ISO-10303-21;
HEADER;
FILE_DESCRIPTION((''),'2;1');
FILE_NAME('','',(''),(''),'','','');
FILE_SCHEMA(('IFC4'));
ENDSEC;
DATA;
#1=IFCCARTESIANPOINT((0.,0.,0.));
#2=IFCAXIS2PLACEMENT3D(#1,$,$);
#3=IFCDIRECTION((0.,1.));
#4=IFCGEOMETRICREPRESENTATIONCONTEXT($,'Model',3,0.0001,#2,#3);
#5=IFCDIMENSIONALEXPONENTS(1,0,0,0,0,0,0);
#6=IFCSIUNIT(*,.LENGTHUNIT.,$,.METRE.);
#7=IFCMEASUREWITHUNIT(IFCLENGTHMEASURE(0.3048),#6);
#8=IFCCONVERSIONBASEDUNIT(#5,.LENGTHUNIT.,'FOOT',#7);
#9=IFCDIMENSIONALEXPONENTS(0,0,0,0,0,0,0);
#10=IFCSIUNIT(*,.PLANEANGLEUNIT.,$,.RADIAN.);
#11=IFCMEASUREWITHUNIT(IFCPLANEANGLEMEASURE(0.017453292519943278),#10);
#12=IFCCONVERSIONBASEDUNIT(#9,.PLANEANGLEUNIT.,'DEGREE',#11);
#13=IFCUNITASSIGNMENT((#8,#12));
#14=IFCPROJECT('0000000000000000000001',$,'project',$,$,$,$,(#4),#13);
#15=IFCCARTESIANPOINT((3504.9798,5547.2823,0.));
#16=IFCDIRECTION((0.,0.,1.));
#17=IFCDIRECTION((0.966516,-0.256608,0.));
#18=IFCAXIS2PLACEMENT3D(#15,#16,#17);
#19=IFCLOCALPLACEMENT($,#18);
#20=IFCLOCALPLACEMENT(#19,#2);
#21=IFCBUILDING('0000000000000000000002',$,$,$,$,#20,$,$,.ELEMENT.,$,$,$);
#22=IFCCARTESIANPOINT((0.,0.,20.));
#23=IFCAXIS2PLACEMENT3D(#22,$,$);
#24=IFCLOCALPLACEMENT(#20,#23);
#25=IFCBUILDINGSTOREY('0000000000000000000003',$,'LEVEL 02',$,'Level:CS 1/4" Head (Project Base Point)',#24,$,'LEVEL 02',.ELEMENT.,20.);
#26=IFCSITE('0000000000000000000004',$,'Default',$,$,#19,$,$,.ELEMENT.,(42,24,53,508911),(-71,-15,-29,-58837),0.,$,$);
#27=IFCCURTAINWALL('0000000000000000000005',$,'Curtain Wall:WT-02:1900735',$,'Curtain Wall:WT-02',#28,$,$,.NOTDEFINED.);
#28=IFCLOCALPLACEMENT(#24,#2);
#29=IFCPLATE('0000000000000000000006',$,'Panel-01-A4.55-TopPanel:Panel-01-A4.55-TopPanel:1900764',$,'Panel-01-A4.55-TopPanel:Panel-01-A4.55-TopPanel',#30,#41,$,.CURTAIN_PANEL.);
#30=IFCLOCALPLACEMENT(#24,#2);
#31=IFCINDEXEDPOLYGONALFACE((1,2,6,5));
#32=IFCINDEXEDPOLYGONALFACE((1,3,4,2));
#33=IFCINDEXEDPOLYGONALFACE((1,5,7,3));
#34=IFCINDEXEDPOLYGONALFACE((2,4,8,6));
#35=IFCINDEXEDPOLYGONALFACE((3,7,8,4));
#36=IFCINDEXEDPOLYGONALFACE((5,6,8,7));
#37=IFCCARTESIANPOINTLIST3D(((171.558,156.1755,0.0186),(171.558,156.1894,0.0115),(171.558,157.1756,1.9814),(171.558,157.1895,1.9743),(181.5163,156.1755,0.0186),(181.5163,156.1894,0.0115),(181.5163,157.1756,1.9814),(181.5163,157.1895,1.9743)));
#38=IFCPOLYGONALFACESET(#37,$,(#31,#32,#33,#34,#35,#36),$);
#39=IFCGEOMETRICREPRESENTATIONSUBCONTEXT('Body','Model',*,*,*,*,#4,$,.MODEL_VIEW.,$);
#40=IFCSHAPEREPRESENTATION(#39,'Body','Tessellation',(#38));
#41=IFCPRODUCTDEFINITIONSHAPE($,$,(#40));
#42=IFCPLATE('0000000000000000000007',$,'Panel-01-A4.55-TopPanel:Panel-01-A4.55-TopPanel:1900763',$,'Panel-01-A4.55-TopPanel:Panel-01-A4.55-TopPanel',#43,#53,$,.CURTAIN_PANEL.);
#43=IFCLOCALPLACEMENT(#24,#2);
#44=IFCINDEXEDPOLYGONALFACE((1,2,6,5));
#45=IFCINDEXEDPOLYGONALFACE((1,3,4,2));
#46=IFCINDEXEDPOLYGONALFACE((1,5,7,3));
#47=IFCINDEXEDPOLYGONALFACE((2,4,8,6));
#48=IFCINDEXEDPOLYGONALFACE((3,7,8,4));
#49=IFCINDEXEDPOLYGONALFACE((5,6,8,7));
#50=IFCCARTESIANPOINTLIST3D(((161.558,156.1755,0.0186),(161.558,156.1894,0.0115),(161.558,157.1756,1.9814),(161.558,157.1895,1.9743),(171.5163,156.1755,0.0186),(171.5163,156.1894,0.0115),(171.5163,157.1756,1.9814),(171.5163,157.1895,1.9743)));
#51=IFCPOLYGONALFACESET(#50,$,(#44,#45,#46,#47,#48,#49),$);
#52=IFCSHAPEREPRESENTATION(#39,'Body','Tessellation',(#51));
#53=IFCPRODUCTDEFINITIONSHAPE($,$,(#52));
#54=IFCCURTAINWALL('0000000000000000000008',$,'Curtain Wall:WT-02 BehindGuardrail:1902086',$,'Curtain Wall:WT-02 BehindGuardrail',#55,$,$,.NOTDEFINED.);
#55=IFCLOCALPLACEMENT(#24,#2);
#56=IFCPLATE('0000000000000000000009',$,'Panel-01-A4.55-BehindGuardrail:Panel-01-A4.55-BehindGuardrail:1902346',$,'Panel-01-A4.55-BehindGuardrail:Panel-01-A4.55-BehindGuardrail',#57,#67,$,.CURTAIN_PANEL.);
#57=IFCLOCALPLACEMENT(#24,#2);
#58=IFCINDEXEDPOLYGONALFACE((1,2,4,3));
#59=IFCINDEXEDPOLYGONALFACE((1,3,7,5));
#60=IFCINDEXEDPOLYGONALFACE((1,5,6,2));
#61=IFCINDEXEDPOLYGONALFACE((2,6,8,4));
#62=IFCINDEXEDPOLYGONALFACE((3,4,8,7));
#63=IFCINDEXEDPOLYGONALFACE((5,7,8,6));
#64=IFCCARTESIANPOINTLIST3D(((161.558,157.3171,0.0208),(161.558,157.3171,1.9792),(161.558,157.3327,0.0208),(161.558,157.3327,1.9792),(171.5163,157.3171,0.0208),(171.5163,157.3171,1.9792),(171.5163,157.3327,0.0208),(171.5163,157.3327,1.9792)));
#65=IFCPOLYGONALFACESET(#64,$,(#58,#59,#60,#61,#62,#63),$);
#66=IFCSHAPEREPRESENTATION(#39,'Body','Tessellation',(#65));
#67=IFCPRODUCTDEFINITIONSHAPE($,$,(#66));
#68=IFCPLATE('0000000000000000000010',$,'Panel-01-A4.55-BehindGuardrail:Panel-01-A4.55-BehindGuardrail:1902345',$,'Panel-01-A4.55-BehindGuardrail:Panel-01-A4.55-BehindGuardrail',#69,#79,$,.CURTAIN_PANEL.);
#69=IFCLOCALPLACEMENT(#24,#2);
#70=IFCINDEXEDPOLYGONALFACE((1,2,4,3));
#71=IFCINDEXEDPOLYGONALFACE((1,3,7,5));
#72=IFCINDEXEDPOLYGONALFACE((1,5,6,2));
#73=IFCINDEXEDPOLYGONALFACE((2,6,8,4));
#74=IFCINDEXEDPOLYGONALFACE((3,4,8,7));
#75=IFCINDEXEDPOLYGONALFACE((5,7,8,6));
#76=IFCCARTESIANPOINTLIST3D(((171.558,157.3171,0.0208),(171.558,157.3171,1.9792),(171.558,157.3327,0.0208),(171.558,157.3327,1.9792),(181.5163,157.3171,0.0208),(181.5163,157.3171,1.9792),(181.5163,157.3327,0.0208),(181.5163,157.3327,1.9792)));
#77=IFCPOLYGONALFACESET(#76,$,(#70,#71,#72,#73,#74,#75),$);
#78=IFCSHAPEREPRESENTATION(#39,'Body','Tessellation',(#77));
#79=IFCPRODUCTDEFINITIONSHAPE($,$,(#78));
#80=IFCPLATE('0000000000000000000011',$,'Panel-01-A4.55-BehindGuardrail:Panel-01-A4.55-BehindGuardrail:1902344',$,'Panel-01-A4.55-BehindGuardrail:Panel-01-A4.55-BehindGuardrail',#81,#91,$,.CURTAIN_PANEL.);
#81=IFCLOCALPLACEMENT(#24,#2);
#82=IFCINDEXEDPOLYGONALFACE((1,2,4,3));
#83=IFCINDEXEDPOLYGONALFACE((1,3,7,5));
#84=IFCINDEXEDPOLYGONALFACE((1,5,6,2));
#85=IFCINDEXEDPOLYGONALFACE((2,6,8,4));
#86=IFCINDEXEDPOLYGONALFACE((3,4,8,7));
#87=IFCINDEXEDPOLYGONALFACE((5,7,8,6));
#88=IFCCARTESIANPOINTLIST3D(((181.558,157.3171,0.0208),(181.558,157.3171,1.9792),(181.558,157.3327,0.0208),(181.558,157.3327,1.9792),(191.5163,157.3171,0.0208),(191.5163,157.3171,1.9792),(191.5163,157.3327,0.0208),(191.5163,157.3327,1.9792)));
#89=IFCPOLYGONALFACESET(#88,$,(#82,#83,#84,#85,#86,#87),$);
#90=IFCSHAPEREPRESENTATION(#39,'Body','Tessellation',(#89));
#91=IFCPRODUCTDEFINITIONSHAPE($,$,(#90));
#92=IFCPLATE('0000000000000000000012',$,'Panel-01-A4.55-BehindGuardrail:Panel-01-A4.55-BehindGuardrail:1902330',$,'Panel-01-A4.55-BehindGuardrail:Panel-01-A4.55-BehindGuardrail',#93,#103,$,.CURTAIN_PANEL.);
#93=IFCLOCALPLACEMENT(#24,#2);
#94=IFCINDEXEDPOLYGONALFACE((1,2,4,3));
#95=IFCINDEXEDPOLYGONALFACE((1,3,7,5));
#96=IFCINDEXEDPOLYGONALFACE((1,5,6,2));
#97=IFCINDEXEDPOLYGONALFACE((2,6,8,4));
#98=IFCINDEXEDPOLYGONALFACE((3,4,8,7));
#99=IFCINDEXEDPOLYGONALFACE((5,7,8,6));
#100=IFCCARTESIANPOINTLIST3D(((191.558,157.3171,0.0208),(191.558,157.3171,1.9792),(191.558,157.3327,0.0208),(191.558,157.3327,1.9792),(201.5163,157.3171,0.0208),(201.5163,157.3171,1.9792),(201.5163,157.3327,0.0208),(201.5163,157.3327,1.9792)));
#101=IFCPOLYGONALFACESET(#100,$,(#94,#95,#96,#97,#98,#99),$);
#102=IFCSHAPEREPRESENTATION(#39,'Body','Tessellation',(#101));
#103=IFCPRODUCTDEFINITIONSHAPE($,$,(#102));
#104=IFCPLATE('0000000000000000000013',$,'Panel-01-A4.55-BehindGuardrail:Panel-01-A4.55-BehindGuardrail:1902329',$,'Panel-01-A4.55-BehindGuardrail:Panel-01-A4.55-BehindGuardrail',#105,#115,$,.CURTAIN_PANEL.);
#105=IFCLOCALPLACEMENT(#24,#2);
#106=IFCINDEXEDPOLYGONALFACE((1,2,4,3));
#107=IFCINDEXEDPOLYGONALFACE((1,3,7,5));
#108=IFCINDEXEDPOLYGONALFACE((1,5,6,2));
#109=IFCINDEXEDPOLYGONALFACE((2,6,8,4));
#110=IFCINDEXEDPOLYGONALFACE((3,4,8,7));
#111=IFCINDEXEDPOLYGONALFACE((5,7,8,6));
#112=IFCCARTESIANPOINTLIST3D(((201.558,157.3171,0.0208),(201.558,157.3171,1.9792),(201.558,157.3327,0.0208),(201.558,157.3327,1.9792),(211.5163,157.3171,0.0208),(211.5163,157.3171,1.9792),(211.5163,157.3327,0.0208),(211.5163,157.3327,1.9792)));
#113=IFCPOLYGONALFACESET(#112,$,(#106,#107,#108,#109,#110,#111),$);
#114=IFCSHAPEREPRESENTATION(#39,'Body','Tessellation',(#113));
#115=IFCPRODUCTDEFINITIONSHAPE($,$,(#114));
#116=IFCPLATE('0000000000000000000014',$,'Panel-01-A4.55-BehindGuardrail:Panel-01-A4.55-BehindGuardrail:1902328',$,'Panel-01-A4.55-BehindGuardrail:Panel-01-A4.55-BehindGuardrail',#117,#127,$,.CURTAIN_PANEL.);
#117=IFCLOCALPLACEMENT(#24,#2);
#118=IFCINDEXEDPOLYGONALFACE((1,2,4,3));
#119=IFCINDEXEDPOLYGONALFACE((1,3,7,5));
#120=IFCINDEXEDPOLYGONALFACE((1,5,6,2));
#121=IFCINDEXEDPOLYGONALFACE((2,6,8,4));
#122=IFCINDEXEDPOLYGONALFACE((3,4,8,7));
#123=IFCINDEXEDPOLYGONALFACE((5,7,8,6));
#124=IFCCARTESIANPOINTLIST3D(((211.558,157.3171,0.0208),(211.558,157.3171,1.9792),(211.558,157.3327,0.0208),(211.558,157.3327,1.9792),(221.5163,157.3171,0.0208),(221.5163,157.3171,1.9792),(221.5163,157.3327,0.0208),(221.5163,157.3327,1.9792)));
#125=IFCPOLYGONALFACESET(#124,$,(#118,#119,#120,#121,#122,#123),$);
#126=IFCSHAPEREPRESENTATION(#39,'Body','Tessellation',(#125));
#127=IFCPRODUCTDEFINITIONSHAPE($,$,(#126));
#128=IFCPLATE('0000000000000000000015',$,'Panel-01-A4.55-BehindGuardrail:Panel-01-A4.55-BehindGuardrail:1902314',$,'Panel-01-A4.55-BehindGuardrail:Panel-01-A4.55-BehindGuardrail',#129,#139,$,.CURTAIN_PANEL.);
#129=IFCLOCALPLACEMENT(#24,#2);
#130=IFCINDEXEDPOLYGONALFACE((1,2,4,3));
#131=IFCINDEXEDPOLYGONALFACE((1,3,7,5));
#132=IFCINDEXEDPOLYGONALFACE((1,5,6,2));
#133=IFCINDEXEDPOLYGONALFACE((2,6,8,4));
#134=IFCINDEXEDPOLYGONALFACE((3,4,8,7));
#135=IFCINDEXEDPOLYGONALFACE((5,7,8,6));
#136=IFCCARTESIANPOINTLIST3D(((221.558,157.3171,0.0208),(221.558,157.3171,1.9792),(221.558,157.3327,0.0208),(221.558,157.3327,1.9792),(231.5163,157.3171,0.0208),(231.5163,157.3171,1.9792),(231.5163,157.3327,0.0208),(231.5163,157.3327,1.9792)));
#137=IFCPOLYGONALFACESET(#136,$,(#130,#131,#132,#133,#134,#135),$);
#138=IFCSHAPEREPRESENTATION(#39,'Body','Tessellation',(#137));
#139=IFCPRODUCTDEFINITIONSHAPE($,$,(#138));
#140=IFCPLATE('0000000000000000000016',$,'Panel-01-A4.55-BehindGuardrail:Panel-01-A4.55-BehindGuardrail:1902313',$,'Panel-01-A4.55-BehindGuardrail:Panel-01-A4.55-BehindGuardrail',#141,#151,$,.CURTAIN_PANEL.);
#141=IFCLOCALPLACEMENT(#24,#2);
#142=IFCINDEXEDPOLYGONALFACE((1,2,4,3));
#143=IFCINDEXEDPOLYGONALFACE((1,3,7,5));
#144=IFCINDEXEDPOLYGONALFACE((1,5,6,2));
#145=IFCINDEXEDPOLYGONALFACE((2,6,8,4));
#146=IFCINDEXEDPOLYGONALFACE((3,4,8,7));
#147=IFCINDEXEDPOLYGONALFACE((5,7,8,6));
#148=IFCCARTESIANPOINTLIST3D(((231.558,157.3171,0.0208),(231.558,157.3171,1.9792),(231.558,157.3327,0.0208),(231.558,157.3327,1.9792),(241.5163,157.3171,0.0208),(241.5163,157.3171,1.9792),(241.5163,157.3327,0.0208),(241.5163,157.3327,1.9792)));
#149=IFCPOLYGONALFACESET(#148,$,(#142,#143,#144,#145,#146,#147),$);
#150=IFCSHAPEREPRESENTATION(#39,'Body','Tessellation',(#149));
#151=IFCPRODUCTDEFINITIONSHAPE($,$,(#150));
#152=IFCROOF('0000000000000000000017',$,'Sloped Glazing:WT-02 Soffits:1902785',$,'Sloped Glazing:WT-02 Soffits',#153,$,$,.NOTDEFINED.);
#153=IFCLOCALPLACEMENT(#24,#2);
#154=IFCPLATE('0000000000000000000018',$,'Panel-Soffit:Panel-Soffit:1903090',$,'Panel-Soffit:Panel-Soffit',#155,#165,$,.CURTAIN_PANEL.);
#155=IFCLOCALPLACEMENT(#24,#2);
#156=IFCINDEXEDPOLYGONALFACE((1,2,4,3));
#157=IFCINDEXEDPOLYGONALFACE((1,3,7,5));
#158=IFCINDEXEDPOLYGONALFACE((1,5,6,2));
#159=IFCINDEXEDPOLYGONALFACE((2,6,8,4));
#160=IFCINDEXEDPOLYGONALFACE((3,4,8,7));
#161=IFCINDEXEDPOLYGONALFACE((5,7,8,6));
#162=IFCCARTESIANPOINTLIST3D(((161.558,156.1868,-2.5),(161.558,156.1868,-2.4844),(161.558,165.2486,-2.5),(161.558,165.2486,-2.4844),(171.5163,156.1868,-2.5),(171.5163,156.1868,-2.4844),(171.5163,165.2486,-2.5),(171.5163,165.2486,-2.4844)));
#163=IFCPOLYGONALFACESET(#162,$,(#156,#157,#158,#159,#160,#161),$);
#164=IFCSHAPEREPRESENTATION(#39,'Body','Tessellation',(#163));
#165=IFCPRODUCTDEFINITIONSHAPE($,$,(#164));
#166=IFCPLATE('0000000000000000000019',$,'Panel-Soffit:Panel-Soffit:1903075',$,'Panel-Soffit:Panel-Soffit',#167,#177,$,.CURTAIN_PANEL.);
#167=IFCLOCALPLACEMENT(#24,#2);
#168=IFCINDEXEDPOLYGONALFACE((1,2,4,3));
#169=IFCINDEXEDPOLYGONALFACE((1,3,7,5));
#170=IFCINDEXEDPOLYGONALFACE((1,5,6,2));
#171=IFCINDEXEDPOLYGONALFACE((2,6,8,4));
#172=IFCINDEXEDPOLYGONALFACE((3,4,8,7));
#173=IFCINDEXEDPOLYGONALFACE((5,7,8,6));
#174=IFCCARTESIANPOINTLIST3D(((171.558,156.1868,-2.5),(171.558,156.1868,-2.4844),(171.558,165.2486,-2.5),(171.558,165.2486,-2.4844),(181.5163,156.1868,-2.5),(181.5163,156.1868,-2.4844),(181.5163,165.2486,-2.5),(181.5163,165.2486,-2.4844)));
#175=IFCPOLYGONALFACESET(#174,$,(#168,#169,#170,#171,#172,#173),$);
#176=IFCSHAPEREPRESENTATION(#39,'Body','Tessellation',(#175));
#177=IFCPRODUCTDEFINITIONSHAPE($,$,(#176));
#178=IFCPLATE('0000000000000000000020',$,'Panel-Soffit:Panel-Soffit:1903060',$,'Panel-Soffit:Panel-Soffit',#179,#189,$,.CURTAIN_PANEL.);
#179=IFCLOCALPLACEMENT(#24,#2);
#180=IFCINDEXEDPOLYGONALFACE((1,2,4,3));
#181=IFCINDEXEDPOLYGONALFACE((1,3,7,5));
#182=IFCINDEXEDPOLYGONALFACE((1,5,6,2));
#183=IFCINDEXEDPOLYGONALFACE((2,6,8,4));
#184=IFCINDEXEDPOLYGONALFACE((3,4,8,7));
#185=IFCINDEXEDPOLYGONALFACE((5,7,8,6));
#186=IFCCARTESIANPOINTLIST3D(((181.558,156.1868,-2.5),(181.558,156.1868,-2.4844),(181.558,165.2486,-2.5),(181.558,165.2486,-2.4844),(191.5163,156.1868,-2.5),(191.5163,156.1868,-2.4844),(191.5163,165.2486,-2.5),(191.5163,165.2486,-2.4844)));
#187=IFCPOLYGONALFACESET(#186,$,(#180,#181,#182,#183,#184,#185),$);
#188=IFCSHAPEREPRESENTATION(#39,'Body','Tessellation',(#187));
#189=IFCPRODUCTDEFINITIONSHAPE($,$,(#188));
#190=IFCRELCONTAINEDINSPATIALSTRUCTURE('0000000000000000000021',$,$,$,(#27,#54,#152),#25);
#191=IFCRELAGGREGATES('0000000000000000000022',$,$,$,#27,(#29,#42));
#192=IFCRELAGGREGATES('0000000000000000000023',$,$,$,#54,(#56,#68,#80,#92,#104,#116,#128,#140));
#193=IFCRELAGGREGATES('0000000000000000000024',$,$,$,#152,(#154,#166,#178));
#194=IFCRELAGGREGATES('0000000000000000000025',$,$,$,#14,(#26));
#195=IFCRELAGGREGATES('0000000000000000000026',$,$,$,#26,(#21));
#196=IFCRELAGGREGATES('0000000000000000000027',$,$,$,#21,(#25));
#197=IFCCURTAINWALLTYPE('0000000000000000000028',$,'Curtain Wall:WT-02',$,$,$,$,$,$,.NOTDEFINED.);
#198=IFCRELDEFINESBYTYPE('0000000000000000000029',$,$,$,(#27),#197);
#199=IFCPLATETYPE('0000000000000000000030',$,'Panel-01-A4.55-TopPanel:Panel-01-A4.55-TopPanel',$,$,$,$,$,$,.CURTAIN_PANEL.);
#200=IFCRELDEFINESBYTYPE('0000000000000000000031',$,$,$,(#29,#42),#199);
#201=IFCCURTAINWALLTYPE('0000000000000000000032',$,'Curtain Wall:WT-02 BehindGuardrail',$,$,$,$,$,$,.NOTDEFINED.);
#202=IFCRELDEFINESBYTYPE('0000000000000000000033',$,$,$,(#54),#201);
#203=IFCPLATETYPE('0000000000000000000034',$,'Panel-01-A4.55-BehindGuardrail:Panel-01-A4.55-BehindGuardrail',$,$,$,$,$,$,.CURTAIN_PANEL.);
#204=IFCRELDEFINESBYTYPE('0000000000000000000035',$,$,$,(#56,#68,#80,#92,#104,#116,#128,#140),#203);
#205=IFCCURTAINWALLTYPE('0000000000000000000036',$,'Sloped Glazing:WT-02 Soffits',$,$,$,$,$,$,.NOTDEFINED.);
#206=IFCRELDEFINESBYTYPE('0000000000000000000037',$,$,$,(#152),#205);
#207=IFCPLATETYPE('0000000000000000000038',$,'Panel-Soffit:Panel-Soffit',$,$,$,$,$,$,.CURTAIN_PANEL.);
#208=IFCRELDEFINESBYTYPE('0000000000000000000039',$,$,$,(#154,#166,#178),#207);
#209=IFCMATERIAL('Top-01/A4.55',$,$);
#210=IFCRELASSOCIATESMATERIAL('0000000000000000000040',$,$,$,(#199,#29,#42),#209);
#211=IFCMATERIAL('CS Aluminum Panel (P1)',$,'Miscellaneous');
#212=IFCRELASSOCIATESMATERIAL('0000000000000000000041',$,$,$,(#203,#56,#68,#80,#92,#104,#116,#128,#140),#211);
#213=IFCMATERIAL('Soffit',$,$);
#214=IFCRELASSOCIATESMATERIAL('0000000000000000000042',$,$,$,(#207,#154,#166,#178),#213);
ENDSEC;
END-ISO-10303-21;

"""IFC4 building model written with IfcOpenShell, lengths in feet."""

from ifc_helpers import new_model, entity, si_unit, converted_unit, direction, frame, origin, place, context, subcontext, project, spatial, indexed_curve, outline, extrude, source, transform, mapped, material, type_object, type_shapes, element, aggregate, save


model = new_model("IFC4")

# Units and contexts
model_context = context("Model", 3, precision=0.0001, world=origin(), true_north=direction((0.0, 1.0)))
body_context = subcontext(model_context, "Body", "Model", "MODEL_VIEW")
ifc_project = project(units=[converted_unit("LENGTHUNIT", "FOOT", entity("IfcLengthMeasure", 0.3048), si_unit("LENGTHUNIT", "METRE"), dimensions=[1, 0, 0, 0, 0, 0, 0]), converted_unit("PLANEANGLEUNIT", "DEGREE", entity("IfcPlaneAngleMeasure", 0.017453292519943278), si_unit("PLANEANGLEUNIT", "RADIAN"), dimensions=[0, 0, 0, 0, 0, 0, 0])], contexts=[model_context])

# Site, building, storey
site_placement = place(None, frame((3504.9798, 5547.2823, 0.0), z_axis=(0.0, 0.0, 1.0), x_axis=(0.966516, -0.256608, 0.0)))
site = spatial("IfcSite", under=ifc_project, at=site_placement, Name="Default", CompositionType="ELEMENT", RefLatitude=(42, 24, 53, 508911), RefLongitude=(-71, -15, -29, -58837), RefElevation=0.0)
building_placement = place(site_placement, origin())
building = spatial("IfcBuilding", under=site, at=building_placement, CompositionType="ELEMENT")
storey_placement = place(building_placement, frame((0.0, 0.0, 20.0)))
storey = spatial("IfcBuildingStorey", under=building, at=storey_placement, Name="LEVEL 02", ObjectType="Level:CS 1/4\" Head (Project Base Point)", LongName="LEVEL 02", CompositionType="ELEMENT", Elevation=20.0)

# Curtain walls, plates
curtain_wall_type_1 = type_object("IfcCurtainWallType", Name="Curtain Wall:WT-02", PredefinedType="NOTDEFINED")
ifc_material_1 = material(Name="CS Aluminum Panel (P1)", Category="Miscellaneous")
curtain_wall_1_placement = place(storey_placement, frame((0.0, 0.0, -20.0)))
curtain_wall_1 = element("IfcCurtainWall", 1, at=curtain_wall_1_placement, inside=storey, type_object=curtain_wall_type_1, Name="Curtain Wall:WT-02:1900735", ObjectType="Curtain Wall:WT-02", PredefinedType="NOTDEFINED")
ifc_material_2 = material(Name="Top-01/A4.55")
plate_type_1 = type_object("IfcPlateType", Name="Panel-01-A4.55-TopPanel:Panel-01-A4.55-TopPanel", PredefinedType="CURTAIN_PANEL", material=ifc_material_2)
shared_shape_1 = source(origin(), body_context, "Body", "SweptSolid", [
    extrude(outline(indexed_curve([(-0.0078, -4.9792), (0.0078, -4.9792), (0.0078, 4.9792), (-0.0078, 4.9792), (-0.0078, -4.9792)], self_intersect=False)), frame((0.0, -0.0078, 0.0208), z_axis=(0.0, 0.0, 1.0), x_axis=(0.0, -1.0, 0.0)), (0.0, 0.0, 1.0), 2.203),
])
type_shapes(plate_type_1, [shared_shape_1])
plate_1_placement = place(curtain_wall_1_placement, frame((176.5372, 156.166, 20.0), z_axis=(0.0, 0.45399, 0.891007), x_axis=(-1.0, 0.0, 0.0)))
plate_1 = element("IfcPlate", 2, at=plate_1_placement, type_object=plate_type_1, material=ifc_material_2, Name="Panel-01-A4.55-TopPanel:Panel-01-A4.55-TopPanel:1900764", ObjectType="Panel-01-A4.55-TopPanel:Panel-01-A4.55-TopPanel", PredefinedType="CURTAIN_PANEL", context=body_context, shape_type="MappedRepresentation", body=[
    mapped(shared_shape_1, transform((0.0, 0.0, 0.0), scale=1.0)),
])
plate_2_placement = place(curtain_wall_1_placement, frame((166.5372, 156.166, 20.0), z_axis=(0.0, 0.45399, 0.891007), x_axis=(-1.0, 0.0, 0.0)))
plate_2 = element("IfcPlate", 3, at=plate_2_placement, type_object=plate_type_1, material=ifc_material_2, Name="Panel-01-A4.55-TopPanel:Panel-01-A4.55-TopPanel:1900763", ObjectType="Panel-01-A4.55-TopPanel:Panel-01-A4.55-TopPanel", PredefinedType="CURTAIN_PANEL", context=body_context, shape_type="MappedRepresentation", body=[
    mapped(shared_shape_1, transform((0.0, 0.0, 0.0), scale=1.0)),
])
aggregate(curtain_wall_1, [plate_1, plate_2])
curtain_wall_type_2 = type_object("IfcCurtainWallType", Name="Curtain Wall:WT-02 BehindGuardrail", PredefinedType="NOTDEFINED")
curtain_wall_2_placement = place(storey_placement, frame((0.0, 0.0, -20.0)))
curtain_wall_2 = element("IfcCurtainWall", 4, at=curtain_wall_2_placement, inside=storey, type_object=curtain_wall_type_2, Name="Curtain Wall:WT-02 BehindGuardrail:1902086", ObjectType="Curtain Wall:WT-02 BehindGuardrail", PredefinedType="NOTDEFINED")
plate_type_2 = type_object("IfcPlateType", Name="Panel-01-A4.55-BehindGuardrail:Panel-01-A4.55-BehindGuardrail", PredefinedType="CURTAIN_PANEL", material=ifc_material_1)
shared_shape_2 = source(origin(), body_context, "Body", "SweptSolid", [
    extrude(outline(indexed_curve([(-0.0078, -4.9792), (0.0078, -4.9792), (0.0078, 4.9792), (-0.0078, 4.9792), (-0.0078, -4.9792)], self_intersect=False)), frame((0.0, -0.0078, 0.0208), z_axis=(0.0, 0.0, 1.0), x_axis=(0.0, -1.0, 0.0)), (0.0, 0.0, 1.0), 1.9583),
])
type_shapes(plate_type_2, [shared_shape_2])
plate_3_placement = place(curtain_wall_2_placement, frame((166.5372, 157.3327, 20.0)))
plate_3 = element("IfcPlate", 5, at=plate_3_placement, type_object=plate_type_2, material=ifc_material_1, Name="Panel-01-A4.55-BehindGuardrail:Panel-01-A4.55-BehindGuardrail:1902346", ObjectType="Panel-01-A4.55-BehindGuardrail:Panel-01-A4.55-BehindGuardrail", PredefinedType="CURTAIN_PANEL", context=body_context, shape_type="MappedRepresentation", body=[
    mapped(shared_shape_2, transform((0.0, 0.0, 0.0), scale=1.0)),
])
plate_4_placement = place(curtain_wall_2_placement, frame((176.5372, 157.3327, 20.0)))
plate_4 = element("IfcPlate", 6, at=plate_4_placement, type_object=plate_type_2, material=ifc_material_1, Name="Panel-01-A4.55-BehindGuardrail:Panel-01-A4.55-BehindGuardrail:1902345", ObjectType="Panel-01-A4.55-BehindGuardrail:Panel-01-A4.55-BehindGuardrail", PredefinedType="CURTAIN_PANEL", context=body_context, shape_type="MappedRepresentation", body=[
    mapped(shared_shape_2, transform((0.0, 0.0, 0.0), scale=1.0)),
])
plate_5_placement = place(curtain_wall_2_placement, frame((186.5372, 157.3327, 20.0)))
plate_5 = element("IfcPlate", 7, at=plate_5_placement, type_object=plate_type_2, material=ifc_material_1, Name="Panel-01-A4.55-BehindGuardrail:Panel-01-A4.55-BehindGuardrail:1902344", ObjectType="Panel-01-A4.55-BehindGuardrail:Panel-01-A4.55-BehindGuardrail", PredefinedType="CURTAIN_PANEL", context=body_context, shape_type="MappedRepresentation", body=[
    mapped(shared_shape_2, transform((0.0, 0.0, 0.0), scale=1.0)),
])
plate_6_placement = place(curtain_wall_2_placement, frame((196.5372, 157.3327, 20.0)))
plate_6 = element("IfcPlate", 8, at=plate_6_placement, type_object=plate_type_2, material=ifc_material_1, Name="Panel-01-A4.55-BehindGuardrail:Panel-01-A4.55-BehindGuardrail:1902330", ObjectType="Panel-01-A4.55-BehindGuardrail:Panel-01-A4.55-BehindGuardrail", PredefinedType="CURTAIN_PANEL", context=body_context, shape_type="MappedRepresentation", body=[
    mapped(shared_shape_2, transform((0.0, 0.0, 0.0), scale=1.0)),
])
plate_7_placement = place(curtain_wall_2_placement, frame((206.5372, 157.3327, 20.0)))
plate_7 = element("IfcPlate", 9, at=plate_7_placement, type_object=plate_type_2, material=ifc_material_1, Name="Panel-01-A4.55-BehindGuardrail:Panel-01-A4.55-BehindGuardrail:1902329", ObjectType="Panel-01-A4.55-BehindGuardrail:Panel-01-A4.55-BehindGuardrail", PredefinedType="CURTAIN_PANEL", context=body_context, shape_type="MappedRepresentation", body=[
    mapped(shared_shape_2, transform((0.0, 0.0, 0.0), scale=1.0)),
])
plate_8_placement = place(curtain_wall_2_placement, frame((216.5372, 157.3327, 20.0)))
plate_8 = element("IfcPlate", 10, at=plate_8_placement, type_object=plate_type_2, material=ifc_material_1, Name="Panel-01-A4.55-BehindGuardrail:Panel-01-A4.55-BehindGuardrail:1902328", ObjectType="Panel-01-A4.55-BehindGuardrail:Panel-01-A4.55-BehindGuardrail", PredefinedType="CURTAIN_PANEL", context=body_context, shape_type="MappedRepresentation", body=[
    mapped(shared_shape_2, transform((0.0, 0.0, 0.0), scale=1.0)),
])
plate_9_placement = place(curtain_wall_2_placement, frame((226.5372, 157.3327, 20.0)))
plate_9 = element("IfcPlate", 11, at=plate_9_placement, type_object=plate_type_2, material=ifc_material_1, Name="Panel-01-A4.55-BehindGuardrail:Panel-01-A4.55-BehindGuardrail:1902314", ObjectType="Panel-01-A4.55-BehindGuardrail:Panel-01-A4.55-BehindGuardrail", PredefinedType="CURTAIN_PANEL", context=body_context, shape_type="MappedRepresentation", body=[
    mapped(shared_shape_2, transform((0.0, 0.0, 0.0), scale=1.0)),
])
plate_10_placement = place(curtain_wall_2_placement, frame((236.5372, 157.3327, 20.0)))
plate_10 = element("IfcPlate", 12, at=plate_10_placement, type_object=plate_type_2, material=ifc_material_1, Name="Panel-01-A4.55-BehindGuardrail:Panel-01-A4.55-BehindGuardrail:1902313", ObjectType="Panel-01-A4.55-BehindGuardrail:Panel-01-A4.55-BehindGuardrail", PredefinedType="CURTAIN_PANEL", context=body_context, shape_type="MappedRepresentation", body=[
    mapped(shared_shape_2, transform((0.0, 0.0, 0.0), scale=1.0)),
])
aggregate(curtain_wall_2, [plate_3, plate_4, plate_5, plate_6, plate_7, plate_8, plate_9, plate_10])

# Roof, plates
curtain_wall_type_3 = type_object("IfcCurtainWallType", Name="Sloped Glazing:WT-02 Soffits", PredefinedType="NOTDEFINED")
roof_placement = place(storey_placement, frame((0.0, 0.0, -20.0)))
roof = element("IfcRoof", 13, at=roof_placement, inside=storey, type_object=curtain_wall_type_3, Name="Sloped Glazing:WT-02 Soffits:1902785", ObjectType="Sloped Glazing:WT-02 Soffits", PredefinedType="NOTDEFINED")
ifc_material_3 = material(Name="Soffit")
plate_type_3 = type_object("IfcPlateType", Name="Panel-Soffit:Panel-Soffit", PredefinedType="CURTAIN_PANEL", material=ifc_material_3)
shared_shape_3 = source(origin(), body_context, "Body", "SweptSolid", [
    extrude(outline(indexed_curve([(-0.0078, -4.9792), (0.0078, -4.9792), (0.0078, 4.9792), (-0.0078, 4.9792), (-0.0078, -4.9792)], self_intersect=False)), frame((0.0, -0.0078, 0.0208), z_axis=(0.0, 0.0, 1.0), x_axis=(0.0, -1.0, 0.0)), (0.0, 0.0, 1.0), 9.0617),
])
type_shapes(plate_type_3, [shared_shape_3])
plate_11_placement = place(roof_placement, frame((166.5372, 156.166, 17.5), z_axis=(0.0, 1.0, 0.0), x_axis=(1.0, 0.0, 0.0)))
plate_11 = element("IfcPlate", 14, at=plate_11_placement, type_object=plate_type_3, material=ifc_material_3, Name="Panel-Soffit:Panel-Soffit:1903090", ObjectType="Panel-Soffit:Panel-Soffit", PredefinedType="CURTAIN_PANEL", context=body_context, shape_type="MappedRepresentation", body=[
    mapped(shared_shape_3, transform((0.0, 0.0, 0.0), scale=1.0)),
])
plate_12_placement = place(roof_placement, frame((176.5372, 156.166, 17.5), z_axis=(0.0, 1.0, 0.0), x_axis=(1.0, 0.0, 0.0)))
plate_12 = element("IfcPlate", 15, at=plate_12_placement, type_object=plate_type_3, material=ifc_material_3, Name="Panel-Soffit:Panel-Soffit:1903075", ObjectType="Panel-Soffit:Panel-Soffit", PredefinedType="CURTAIN_PANEL", context=body_context, shape_type="MappedRepresentation", body=[
    mapped(shared_shape_3, transform((0.0, 0.0, 0.0), scale=1.0)),
])
plate_13_placement = place(roof_placement, frame((186.5372, 156.166, 17.5), z_axis=(0.0, 1.0, 0.0), x_axis=(1.0, 0.0, 0.0)))
plate_13 = element("IfcPlate", 16, at=plate_13_placement, type_object=plate_type_3, material=ifc_material_3, Name="Panel-Soffit:Panel-Soffit:1903060", ObjectType="Panel-Soffit:Panel-Soffit", PredefinedType="CURTAIN_PANEL", context=body_context, shape_type="MappedRepresentation", body=[
    mapped(shared_shape_3, transform((0.0, 0.0, 0.0), scale=1.0)),
])
aggregate(roof, [plate_11, plate_12, plate_13])

save(model, "model.ifc")
